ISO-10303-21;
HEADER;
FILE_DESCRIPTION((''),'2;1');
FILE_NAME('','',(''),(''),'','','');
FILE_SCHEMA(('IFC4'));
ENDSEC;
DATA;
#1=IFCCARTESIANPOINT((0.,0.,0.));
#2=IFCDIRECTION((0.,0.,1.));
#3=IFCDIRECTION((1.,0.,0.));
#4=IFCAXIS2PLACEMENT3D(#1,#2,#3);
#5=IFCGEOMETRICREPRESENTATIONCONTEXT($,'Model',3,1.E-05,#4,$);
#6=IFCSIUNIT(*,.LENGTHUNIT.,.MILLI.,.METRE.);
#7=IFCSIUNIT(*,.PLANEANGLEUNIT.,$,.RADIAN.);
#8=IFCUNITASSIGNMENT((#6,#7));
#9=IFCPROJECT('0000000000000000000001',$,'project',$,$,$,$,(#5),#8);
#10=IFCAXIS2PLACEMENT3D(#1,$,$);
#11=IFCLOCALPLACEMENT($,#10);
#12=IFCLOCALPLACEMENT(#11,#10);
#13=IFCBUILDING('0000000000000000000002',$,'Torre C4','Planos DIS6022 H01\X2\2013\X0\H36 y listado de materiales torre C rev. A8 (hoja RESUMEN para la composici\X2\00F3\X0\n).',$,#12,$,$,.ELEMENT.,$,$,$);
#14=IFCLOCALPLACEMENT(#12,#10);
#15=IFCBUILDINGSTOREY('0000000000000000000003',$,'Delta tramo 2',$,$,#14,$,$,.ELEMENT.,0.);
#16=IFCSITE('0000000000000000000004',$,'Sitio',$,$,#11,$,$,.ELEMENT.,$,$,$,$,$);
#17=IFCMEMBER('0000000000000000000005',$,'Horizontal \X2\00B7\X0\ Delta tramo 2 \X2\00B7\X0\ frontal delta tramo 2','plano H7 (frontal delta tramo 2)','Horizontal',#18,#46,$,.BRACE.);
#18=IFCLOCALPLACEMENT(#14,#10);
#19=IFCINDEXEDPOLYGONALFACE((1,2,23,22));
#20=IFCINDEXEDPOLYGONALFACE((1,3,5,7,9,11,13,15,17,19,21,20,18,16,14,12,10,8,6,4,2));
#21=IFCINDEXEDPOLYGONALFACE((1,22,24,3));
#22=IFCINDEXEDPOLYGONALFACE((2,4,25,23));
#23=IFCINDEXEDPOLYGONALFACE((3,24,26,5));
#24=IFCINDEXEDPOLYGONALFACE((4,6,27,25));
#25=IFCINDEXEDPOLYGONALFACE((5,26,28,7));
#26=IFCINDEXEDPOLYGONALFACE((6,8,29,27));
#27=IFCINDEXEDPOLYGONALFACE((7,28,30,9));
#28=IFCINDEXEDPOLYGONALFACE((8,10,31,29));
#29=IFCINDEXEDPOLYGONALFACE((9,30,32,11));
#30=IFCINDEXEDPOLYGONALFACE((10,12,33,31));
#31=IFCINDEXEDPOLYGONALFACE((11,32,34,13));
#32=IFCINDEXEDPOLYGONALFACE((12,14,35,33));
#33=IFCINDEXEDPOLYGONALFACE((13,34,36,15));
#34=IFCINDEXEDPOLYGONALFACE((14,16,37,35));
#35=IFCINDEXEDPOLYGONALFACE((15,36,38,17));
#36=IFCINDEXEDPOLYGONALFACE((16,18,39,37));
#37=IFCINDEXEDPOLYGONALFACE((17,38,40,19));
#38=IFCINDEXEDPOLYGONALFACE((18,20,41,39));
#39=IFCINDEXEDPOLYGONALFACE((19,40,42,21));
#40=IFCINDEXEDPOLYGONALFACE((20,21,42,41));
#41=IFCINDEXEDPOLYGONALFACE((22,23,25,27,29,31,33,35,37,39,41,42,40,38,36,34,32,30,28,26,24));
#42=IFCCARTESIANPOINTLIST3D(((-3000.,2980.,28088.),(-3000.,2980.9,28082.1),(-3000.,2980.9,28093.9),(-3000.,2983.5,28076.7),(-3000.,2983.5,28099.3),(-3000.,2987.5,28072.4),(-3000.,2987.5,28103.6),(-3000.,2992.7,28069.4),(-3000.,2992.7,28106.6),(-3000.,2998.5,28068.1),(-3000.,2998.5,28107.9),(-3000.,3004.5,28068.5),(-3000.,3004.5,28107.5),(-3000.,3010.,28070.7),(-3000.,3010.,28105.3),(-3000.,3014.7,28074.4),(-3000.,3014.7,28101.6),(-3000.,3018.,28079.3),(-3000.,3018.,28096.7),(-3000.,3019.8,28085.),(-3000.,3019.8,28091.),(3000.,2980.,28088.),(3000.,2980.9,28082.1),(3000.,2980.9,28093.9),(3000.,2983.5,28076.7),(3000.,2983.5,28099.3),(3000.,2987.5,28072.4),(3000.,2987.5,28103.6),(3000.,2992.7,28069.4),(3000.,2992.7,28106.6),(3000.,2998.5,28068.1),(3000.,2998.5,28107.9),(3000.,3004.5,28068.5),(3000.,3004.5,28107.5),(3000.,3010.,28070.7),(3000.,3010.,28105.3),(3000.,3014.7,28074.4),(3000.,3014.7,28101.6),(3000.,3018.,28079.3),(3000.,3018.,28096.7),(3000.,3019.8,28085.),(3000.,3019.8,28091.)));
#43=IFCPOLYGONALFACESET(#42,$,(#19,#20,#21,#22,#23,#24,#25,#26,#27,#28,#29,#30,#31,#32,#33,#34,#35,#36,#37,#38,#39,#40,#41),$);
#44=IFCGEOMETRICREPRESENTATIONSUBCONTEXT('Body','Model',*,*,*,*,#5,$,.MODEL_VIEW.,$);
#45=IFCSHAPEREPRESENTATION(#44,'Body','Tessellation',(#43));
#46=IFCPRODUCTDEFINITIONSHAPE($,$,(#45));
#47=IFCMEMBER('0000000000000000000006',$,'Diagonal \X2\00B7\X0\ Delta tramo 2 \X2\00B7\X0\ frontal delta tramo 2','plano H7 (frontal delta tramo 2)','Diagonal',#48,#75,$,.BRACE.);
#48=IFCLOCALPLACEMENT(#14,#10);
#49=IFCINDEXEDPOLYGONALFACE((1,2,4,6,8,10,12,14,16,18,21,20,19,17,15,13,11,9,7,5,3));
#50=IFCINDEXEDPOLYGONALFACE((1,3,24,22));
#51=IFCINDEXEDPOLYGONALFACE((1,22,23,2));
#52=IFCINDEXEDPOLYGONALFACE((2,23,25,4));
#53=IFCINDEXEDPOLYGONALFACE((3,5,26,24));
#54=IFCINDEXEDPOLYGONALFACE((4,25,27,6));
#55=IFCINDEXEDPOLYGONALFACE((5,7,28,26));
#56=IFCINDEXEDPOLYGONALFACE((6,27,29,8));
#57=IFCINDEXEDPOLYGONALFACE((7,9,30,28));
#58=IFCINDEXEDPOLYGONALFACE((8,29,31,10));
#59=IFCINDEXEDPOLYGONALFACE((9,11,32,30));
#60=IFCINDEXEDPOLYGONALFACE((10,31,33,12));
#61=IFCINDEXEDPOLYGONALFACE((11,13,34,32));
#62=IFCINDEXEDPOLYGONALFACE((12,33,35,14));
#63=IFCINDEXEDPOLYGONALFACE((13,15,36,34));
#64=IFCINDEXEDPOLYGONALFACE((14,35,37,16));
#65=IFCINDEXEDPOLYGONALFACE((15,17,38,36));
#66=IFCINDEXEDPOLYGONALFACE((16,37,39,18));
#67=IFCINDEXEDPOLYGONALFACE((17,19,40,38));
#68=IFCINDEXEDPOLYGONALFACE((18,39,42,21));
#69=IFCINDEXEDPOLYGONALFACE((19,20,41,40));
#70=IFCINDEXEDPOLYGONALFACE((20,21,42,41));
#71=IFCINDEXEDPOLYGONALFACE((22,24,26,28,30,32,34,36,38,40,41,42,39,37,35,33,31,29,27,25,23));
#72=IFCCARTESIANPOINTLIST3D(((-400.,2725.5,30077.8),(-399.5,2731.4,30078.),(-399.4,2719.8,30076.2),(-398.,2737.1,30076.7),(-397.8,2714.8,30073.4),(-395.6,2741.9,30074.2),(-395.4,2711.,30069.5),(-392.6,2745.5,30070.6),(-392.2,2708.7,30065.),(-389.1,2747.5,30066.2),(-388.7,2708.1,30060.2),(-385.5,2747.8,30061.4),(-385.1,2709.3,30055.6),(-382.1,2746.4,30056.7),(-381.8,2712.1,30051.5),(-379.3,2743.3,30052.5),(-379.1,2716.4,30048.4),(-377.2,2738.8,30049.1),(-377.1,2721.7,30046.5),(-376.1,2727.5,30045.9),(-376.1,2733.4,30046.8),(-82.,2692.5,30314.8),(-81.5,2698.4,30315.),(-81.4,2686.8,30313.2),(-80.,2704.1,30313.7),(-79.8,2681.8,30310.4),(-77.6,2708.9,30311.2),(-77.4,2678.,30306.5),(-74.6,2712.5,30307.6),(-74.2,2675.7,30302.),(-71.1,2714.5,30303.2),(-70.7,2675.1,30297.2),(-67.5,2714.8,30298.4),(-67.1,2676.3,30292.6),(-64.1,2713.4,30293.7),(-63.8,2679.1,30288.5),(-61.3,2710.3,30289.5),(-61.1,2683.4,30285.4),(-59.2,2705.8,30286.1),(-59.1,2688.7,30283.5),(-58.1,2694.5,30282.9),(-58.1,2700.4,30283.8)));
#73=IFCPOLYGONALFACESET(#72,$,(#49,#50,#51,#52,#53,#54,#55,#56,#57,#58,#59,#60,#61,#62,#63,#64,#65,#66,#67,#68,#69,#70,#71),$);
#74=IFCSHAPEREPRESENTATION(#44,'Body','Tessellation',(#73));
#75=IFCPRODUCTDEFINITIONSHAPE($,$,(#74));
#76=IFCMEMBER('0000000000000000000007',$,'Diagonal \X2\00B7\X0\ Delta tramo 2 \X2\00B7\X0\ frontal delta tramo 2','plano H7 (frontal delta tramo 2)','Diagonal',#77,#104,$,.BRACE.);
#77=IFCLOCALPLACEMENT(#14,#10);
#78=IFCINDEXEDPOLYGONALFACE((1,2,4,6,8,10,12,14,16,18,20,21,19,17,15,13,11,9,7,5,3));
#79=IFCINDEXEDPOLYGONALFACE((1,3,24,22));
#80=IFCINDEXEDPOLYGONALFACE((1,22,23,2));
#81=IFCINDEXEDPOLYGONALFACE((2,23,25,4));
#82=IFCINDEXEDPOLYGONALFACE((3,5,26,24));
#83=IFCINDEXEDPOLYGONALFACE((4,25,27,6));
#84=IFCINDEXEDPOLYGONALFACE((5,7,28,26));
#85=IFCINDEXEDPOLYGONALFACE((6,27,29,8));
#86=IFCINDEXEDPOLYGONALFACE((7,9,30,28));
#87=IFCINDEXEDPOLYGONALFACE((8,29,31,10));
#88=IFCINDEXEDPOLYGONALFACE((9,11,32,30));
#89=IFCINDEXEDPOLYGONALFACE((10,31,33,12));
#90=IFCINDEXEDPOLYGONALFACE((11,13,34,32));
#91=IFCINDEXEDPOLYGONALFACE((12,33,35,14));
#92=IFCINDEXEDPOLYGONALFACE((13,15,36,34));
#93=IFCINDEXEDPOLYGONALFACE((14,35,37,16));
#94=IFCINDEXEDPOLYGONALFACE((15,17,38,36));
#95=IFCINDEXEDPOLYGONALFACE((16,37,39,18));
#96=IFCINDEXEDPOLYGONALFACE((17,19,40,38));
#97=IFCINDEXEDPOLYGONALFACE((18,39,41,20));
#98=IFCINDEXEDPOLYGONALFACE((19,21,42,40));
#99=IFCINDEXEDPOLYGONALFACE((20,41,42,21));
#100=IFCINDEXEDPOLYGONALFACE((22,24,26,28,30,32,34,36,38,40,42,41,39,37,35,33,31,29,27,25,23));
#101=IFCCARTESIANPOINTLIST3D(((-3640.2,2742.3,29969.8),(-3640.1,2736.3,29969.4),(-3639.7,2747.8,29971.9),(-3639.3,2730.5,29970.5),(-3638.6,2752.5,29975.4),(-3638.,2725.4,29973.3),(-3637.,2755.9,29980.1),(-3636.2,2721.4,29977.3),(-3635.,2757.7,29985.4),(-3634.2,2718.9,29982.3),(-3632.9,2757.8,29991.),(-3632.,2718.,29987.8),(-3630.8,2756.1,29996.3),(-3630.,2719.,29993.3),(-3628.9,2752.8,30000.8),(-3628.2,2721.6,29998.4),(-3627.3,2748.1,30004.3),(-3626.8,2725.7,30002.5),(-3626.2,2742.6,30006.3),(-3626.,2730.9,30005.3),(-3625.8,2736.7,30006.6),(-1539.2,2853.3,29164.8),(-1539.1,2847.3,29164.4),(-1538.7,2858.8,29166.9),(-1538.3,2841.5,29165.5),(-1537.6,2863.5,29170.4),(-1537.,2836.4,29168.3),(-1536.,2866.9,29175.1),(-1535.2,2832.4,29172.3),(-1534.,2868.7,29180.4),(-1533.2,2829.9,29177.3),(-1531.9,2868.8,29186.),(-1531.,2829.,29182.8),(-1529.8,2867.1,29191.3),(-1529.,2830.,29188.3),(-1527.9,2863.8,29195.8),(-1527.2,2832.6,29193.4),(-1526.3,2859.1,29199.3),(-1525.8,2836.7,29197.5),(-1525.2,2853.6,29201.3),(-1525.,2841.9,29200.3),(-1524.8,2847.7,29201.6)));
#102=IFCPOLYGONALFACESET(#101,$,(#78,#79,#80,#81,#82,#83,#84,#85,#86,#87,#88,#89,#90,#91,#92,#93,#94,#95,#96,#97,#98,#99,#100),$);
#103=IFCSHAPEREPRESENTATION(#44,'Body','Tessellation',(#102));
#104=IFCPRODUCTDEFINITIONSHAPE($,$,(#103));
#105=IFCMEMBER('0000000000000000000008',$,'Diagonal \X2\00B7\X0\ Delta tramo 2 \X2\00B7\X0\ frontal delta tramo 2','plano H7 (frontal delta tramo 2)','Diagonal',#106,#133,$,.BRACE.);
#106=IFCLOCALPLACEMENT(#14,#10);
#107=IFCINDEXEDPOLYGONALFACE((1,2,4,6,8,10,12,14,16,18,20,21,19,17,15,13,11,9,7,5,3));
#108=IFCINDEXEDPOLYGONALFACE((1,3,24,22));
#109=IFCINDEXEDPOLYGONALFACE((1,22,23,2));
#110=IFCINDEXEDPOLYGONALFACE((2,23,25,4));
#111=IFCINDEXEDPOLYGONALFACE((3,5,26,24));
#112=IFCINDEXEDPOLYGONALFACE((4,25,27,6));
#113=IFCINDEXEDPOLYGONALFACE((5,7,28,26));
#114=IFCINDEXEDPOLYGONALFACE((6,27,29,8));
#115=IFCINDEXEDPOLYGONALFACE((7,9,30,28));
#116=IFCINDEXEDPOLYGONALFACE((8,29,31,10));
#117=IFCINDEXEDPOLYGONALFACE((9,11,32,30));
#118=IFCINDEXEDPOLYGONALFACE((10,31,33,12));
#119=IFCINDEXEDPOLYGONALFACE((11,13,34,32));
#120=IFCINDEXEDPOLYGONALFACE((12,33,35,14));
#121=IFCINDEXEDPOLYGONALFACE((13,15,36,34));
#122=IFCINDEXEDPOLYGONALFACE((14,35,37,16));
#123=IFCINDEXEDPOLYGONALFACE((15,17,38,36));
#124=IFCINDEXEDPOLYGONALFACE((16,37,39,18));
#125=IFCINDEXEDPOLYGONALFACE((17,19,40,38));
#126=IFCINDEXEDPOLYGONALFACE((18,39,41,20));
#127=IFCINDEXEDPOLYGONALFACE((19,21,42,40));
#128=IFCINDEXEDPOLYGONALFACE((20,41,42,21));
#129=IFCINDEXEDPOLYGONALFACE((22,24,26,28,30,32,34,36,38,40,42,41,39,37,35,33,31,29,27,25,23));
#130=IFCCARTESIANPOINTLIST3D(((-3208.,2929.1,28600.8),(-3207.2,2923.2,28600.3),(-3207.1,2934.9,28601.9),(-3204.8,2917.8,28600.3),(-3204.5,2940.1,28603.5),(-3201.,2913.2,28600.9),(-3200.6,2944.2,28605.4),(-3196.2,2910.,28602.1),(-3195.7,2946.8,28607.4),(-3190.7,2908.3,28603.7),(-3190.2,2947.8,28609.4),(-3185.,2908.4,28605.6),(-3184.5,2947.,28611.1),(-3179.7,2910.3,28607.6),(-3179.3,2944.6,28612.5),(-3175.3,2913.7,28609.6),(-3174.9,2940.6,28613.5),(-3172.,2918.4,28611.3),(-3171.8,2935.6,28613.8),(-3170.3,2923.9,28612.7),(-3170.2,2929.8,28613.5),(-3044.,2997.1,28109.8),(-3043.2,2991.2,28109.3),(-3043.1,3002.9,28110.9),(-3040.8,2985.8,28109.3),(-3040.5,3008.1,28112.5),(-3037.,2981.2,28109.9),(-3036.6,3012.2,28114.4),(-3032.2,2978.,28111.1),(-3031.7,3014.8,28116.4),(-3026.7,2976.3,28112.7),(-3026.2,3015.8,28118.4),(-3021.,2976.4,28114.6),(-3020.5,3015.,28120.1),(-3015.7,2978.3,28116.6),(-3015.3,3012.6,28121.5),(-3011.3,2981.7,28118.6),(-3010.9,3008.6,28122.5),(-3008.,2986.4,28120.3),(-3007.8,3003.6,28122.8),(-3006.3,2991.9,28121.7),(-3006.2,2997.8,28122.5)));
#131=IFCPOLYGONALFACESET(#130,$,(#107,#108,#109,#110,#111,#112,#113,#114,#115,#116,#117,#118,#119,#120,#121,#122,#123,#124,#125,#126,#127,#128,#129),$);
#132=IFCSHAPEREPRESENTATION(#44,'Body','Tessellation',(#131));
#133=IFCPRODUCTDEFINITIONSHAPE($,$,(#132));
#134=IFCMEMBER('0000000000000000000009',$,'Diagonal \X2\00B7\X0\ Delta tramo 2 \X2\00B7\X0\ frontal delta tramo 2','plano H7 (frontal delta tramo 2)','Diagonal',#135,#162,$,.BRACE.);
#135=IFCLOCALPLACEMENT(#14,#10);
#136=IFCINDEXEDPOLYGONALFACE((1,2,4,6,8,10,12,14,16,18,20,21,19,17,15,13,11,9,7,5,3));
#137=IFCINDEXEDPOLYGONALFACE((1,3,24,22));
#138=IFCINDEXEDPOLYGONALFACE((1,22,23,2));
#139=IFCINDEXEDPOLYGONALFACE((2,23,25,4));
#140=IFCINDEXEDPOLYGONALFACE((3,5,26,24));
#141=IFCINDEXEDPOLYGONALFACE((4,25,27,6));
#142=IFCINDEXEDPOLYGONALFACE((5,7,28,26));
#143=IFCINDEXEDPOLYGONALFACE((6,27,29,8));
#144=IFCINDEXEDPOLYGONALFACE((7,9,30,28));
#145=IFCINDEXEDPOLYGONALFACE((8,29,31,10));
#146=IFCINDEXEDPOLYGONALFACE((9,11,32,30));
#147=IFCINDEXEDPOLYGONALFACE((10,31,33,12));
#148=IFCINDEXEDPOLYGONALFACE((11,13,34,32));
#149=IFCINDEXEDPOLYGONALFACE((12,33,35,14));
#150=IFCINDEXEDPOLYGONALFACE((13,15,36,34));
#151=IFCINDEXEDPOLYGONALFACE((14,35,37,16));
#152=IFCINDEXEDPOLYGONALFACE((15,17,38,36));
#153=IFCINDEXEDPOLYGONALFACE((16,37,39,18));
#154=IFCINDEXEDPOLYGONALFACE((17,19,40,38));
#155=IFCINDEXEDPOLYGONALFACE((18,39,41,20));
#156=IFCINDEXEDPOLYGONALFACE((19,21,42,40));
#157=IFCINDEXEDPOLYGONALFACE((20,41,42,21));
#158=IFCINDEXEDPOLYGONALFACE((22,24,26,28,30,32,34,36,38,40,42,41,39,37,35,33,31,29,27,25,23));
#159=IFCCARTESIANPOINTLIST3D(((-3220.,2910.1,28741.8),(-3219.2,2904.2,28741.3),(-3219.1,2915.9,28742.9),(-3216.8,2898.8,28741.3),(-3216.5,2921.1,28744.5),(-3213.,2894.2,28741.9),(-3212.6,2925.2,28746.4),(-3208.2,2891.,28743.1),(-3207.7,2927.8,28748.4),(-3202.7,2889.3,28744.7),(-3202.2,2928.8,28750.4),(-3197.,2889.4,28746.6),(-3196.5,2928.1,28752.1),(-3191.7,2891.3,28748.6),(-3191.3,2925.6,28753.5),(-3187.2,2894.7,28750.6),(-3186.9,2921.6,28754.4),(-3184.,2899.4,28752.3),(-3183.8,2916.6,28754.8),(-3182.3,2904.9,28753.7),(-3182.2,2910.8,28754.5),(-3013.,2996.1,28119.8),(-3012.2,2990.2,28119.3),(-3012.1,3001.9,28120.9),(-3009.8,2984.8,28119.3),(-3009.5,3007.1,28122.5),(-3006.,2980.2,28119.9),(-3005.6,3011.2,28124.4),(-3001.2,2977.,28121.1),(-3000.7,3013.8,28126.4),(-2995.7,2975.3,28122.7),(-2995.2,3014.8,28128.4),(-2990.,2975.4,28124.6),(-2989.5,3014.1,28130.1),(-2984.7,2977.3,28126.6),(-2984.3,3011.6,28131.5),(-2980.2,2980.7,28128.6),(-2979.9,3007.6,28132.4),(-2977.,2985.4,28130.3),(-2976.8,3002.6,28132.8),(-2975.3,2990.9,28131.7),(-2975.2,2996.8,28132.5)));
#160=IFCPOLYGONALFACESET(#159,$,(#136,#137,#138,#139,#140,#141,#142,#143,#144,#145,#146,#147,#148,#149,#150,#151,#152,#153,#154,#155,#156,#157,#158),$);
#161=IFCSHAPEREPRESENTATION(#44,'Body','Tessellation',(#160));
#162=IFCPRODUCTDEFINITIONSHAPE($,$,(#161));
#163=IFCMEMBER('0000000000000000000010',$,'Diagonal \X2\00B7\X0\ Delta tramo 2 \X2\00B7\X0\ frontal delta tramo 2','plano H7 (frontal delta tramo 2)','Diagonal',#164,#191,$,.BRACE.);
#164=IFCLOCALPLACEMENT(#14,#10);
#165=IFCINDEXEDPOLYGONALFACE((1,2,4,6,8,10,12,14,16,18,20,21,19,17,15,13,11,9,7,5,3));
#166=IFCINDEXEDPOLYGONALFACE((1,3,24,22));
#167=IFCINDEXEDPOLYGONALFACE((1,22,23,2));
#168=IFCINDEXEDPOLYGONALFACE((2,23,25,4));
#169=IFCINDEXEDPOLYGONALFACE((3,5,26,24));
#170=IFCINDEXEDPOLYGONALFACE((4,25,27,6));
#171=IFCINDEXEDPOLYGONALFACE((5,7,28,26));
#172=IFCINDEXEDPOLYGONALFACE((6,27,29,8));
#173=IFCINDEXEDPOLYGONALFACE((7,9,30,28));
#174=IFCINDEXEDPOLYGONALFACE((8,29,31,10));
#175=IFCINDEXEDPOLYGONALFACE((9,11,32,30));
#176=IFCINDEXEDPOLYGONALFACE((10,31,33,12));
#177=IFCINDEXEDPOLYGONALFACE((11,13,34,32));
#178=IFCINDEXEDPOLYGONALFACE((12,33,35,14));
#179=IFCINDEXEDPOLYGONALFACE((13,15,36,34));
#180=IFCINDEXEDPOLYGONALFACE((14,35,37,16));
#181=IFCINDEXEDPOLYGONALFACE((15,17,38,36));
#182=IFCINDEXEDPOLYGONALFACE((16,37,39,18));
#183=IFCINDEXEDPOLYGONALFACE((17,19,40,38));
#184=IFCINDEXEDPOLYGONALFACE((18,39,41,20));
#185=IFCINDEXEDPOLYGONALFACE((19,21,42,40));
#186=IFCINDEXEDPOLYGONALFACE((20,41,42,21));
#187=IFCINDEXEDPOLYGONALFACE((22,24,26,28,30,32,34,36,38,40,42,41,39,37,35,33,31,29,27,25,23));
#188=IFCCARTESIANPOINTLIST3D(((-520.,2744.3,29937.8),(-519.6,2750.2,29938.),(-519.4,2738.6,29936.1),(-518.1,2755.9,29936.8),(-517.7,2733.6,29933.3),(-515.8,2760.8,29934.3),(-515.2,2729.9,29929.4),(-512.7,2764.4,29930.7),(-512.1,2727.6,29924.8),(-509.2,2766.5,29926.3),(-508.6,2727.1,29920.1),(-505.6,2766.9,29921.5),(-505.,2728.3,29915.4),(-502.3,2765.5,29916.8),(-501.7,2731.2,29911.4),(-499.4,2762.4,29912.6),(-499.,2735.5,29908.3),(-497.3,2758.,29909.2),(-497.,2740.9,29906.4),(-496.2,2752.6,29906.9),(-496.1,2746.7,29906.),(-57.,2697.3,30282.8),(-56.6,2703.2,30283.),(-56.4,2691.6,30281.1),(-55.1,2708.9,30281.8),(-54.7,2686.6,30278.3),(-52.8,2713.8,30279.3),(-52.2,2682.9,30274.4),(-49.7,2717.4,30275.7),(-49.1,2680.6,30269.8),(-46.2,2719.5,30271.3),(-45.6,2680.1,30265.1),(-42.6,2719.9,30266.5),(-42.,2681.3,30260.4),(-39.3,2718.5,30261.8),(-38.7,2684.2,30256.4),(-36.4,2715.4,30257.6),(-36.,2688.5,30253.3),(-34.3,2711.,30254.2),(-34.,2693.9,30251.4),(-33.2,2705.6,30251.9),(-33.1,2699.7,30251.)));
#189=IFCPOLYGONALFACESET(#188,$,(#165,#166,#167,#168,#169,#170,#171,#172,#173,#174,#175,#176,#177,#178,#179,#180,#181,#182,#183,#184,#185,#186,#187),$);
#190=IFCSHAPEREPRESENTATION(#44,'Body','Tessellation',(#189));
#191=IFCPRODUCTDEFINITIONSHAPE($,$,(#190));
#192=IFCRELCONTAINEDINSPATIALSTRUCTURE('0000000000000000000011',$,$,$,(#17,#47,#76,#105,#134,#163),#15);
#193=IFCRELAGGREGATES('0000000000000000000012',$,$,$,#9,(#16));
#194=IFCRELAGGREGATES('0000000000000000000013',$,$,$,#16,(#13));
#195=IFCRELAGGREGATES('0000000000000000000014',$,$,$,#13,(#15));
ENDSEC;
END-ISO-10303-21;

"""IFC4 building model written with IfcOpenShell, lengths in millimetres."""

from ifc_helpers import new_model, si_unit, frame, origin, origin_with_axes, place, context, subcontext, project, spatial, circle, extrude, element, save


model = new_model("IFC4")

# Units and contexts
model_context = context("Model", 3, precision=1e-05, world=origin_with_axes())
body_context = subcontext(model_context, "Body", "Model", "MODEL_VIEW")
ifc_project = project(units=[si_unit("LENGTHUNIT", "METRE", prefix="MILLI"), si_unit("PLANEANGLEUNIT", "RADIAN")], contexts=[model_context])

# Site, building, storey
site_placement = place(None, origin())
site = spatial("IfcSite", under=ifc_project, at=site_placement, Name="Sitio", CompositionType="ELEMENT")
building_placement = place(site_placement, origin())
building = spatial("IfcBuilding", under=site, at=building_placement, Name="Torre C4", Description="Planos DIS6022 H01–H36 y listado de materiales torre C rev. A8 (hoja RESUMEN para la composición).", CompositionType="ELEMENT")
storey_placement = place(building_placement, origin())
storey = spatial("IfcBuildingStorey", under=building, at=storey_placement, Name="Delta tramo 2", CompositionType="ELEMENT", Elevation=0.0)

# Members
member_1_placement = place(storey_placement, frame((-3000.0, 3000.0, 28088.0), z_axis=(1.0, 0.0, 0.0), x_axis=(0.0, -1.0, 0.0)))
element("IfcMember", 1, at=member_1_placement, inside=storey, Name="Horizontal · Delta tramo 2 · frontal delta tramo 2", Description="plano H7 (frontal delta tramo 2)", ObjectType="Horizontal", PredefinedType="BRACE", context=body_context, shape_type="SweptSolid", body=[
    extrude(circle(Radius=20.0), None, (0.0, 0.0, 1.0), 6000.0),
])
member_2_placement = place(storey_placement, frame((-70.0, 2695.0, 30299.0), z_axis=(-0.79905, 0.08292, -0.595519), x_axis=(-0.036005, -0.995266, -0.09027)))
element("IfcMember", 2, at=member_2_placement, inside=storey, Name="Diagonal · Delta tramo 2 · frontal delta tramo 2", Description="plano H7 (frontal delta tramo 2)", ObjectType="Diagonal", PredefinedType="BRACE", context=body_context, shape_type="SweptSolid", body=[
    extrude(circle(Radius=20.0), None, (0.0, 0.0, 1.0), 398.0),
])
member_3_placement = place(storey_placement, frame((-1532.0, 2849.0, 29183.0), z_axis=(-0.932669, -0.049275, 0.357353), x_axis=(0.152168, -0.951918, 0.26589)))
element("IfcMember", 3, at=member_3_placement, inside=storey, Name="Diagonal · Delta tramo 2 · frontal delta tramo 2", Description="plano H7 (frontal delta tramo 2)", ObjectType="Diagonal", PredefinedType="BRACE", context=body_context, shape_type="SweptSolid", body=[
    extrude(circle(Radius=20.0), None, (0.0, 0.0, 1.0), 2252.7),
])
member_4_placement = place(storey_placement, frame((-3025.0, 2996.0, 28116.0), z_axis=(-0.314109, -0.13024, 0.940411), x_axis=(0.687135, -0.714708, 0.130529)))
element("IfcMember", 4, at=member_4_placement, inside=storey, Name="Diagonal · Delta tramo 2 · frontal delta tramo 2", Description="plano H7 (frontal delta tramo 2)", ObjectType="Diagonal", PredefinedType="BRACE", context=body_context, shape_type="SweptSolid", body=[
    extrude(circle(Radius=20.0), None, (0.0, 0.0, 1.0), 522.1),
])
member_5_placement = place(storey_placement, frame((-2994.0, 2995.0, 28126.0), z_axis=(-0.313087, -0.130075, 0.940775), x_axis=(0.687514, -0.714436, 0.130023)))
element("IfcMember", 5, at=member_5_placement, inside=storey, Name="Diagonal · Delta tramo 2 · frontal delta tramo 2", Description="plano H7 (frontal delta tramo 2)", ObjectType="Diagonal", PredefinedType="BRACE", context=body_context, shape_type="SweptSolid", body=[
    extrude(circle(Radius=20.0), None, (0.0, 0.0, 1.0), 661.2),
])
member_6_placement = place(storey_placement, frame((-45.0, 2700.0, 30267.0), z_axis=(-0.799223, 0.081131, -0.595533), x_axis=(-0.028395, -0.994838, -0.097421)))
element("IfcMember", 6, at=member_6_placement, inside=storey, Name="Diagonal · Delta tramo 2 · frontal delta tramo 2", Description="plano H7 (frontal delta tramo 2)", ObjectType="Diagonal", PredefinedType="BRACE", context=body_context, shape_type="SweptSolid", body=[
    extrude(circle(Radius=20.0), None, (0.0, 0.0, 1.0), 579.3),
])

save(model, "model.ifc")
